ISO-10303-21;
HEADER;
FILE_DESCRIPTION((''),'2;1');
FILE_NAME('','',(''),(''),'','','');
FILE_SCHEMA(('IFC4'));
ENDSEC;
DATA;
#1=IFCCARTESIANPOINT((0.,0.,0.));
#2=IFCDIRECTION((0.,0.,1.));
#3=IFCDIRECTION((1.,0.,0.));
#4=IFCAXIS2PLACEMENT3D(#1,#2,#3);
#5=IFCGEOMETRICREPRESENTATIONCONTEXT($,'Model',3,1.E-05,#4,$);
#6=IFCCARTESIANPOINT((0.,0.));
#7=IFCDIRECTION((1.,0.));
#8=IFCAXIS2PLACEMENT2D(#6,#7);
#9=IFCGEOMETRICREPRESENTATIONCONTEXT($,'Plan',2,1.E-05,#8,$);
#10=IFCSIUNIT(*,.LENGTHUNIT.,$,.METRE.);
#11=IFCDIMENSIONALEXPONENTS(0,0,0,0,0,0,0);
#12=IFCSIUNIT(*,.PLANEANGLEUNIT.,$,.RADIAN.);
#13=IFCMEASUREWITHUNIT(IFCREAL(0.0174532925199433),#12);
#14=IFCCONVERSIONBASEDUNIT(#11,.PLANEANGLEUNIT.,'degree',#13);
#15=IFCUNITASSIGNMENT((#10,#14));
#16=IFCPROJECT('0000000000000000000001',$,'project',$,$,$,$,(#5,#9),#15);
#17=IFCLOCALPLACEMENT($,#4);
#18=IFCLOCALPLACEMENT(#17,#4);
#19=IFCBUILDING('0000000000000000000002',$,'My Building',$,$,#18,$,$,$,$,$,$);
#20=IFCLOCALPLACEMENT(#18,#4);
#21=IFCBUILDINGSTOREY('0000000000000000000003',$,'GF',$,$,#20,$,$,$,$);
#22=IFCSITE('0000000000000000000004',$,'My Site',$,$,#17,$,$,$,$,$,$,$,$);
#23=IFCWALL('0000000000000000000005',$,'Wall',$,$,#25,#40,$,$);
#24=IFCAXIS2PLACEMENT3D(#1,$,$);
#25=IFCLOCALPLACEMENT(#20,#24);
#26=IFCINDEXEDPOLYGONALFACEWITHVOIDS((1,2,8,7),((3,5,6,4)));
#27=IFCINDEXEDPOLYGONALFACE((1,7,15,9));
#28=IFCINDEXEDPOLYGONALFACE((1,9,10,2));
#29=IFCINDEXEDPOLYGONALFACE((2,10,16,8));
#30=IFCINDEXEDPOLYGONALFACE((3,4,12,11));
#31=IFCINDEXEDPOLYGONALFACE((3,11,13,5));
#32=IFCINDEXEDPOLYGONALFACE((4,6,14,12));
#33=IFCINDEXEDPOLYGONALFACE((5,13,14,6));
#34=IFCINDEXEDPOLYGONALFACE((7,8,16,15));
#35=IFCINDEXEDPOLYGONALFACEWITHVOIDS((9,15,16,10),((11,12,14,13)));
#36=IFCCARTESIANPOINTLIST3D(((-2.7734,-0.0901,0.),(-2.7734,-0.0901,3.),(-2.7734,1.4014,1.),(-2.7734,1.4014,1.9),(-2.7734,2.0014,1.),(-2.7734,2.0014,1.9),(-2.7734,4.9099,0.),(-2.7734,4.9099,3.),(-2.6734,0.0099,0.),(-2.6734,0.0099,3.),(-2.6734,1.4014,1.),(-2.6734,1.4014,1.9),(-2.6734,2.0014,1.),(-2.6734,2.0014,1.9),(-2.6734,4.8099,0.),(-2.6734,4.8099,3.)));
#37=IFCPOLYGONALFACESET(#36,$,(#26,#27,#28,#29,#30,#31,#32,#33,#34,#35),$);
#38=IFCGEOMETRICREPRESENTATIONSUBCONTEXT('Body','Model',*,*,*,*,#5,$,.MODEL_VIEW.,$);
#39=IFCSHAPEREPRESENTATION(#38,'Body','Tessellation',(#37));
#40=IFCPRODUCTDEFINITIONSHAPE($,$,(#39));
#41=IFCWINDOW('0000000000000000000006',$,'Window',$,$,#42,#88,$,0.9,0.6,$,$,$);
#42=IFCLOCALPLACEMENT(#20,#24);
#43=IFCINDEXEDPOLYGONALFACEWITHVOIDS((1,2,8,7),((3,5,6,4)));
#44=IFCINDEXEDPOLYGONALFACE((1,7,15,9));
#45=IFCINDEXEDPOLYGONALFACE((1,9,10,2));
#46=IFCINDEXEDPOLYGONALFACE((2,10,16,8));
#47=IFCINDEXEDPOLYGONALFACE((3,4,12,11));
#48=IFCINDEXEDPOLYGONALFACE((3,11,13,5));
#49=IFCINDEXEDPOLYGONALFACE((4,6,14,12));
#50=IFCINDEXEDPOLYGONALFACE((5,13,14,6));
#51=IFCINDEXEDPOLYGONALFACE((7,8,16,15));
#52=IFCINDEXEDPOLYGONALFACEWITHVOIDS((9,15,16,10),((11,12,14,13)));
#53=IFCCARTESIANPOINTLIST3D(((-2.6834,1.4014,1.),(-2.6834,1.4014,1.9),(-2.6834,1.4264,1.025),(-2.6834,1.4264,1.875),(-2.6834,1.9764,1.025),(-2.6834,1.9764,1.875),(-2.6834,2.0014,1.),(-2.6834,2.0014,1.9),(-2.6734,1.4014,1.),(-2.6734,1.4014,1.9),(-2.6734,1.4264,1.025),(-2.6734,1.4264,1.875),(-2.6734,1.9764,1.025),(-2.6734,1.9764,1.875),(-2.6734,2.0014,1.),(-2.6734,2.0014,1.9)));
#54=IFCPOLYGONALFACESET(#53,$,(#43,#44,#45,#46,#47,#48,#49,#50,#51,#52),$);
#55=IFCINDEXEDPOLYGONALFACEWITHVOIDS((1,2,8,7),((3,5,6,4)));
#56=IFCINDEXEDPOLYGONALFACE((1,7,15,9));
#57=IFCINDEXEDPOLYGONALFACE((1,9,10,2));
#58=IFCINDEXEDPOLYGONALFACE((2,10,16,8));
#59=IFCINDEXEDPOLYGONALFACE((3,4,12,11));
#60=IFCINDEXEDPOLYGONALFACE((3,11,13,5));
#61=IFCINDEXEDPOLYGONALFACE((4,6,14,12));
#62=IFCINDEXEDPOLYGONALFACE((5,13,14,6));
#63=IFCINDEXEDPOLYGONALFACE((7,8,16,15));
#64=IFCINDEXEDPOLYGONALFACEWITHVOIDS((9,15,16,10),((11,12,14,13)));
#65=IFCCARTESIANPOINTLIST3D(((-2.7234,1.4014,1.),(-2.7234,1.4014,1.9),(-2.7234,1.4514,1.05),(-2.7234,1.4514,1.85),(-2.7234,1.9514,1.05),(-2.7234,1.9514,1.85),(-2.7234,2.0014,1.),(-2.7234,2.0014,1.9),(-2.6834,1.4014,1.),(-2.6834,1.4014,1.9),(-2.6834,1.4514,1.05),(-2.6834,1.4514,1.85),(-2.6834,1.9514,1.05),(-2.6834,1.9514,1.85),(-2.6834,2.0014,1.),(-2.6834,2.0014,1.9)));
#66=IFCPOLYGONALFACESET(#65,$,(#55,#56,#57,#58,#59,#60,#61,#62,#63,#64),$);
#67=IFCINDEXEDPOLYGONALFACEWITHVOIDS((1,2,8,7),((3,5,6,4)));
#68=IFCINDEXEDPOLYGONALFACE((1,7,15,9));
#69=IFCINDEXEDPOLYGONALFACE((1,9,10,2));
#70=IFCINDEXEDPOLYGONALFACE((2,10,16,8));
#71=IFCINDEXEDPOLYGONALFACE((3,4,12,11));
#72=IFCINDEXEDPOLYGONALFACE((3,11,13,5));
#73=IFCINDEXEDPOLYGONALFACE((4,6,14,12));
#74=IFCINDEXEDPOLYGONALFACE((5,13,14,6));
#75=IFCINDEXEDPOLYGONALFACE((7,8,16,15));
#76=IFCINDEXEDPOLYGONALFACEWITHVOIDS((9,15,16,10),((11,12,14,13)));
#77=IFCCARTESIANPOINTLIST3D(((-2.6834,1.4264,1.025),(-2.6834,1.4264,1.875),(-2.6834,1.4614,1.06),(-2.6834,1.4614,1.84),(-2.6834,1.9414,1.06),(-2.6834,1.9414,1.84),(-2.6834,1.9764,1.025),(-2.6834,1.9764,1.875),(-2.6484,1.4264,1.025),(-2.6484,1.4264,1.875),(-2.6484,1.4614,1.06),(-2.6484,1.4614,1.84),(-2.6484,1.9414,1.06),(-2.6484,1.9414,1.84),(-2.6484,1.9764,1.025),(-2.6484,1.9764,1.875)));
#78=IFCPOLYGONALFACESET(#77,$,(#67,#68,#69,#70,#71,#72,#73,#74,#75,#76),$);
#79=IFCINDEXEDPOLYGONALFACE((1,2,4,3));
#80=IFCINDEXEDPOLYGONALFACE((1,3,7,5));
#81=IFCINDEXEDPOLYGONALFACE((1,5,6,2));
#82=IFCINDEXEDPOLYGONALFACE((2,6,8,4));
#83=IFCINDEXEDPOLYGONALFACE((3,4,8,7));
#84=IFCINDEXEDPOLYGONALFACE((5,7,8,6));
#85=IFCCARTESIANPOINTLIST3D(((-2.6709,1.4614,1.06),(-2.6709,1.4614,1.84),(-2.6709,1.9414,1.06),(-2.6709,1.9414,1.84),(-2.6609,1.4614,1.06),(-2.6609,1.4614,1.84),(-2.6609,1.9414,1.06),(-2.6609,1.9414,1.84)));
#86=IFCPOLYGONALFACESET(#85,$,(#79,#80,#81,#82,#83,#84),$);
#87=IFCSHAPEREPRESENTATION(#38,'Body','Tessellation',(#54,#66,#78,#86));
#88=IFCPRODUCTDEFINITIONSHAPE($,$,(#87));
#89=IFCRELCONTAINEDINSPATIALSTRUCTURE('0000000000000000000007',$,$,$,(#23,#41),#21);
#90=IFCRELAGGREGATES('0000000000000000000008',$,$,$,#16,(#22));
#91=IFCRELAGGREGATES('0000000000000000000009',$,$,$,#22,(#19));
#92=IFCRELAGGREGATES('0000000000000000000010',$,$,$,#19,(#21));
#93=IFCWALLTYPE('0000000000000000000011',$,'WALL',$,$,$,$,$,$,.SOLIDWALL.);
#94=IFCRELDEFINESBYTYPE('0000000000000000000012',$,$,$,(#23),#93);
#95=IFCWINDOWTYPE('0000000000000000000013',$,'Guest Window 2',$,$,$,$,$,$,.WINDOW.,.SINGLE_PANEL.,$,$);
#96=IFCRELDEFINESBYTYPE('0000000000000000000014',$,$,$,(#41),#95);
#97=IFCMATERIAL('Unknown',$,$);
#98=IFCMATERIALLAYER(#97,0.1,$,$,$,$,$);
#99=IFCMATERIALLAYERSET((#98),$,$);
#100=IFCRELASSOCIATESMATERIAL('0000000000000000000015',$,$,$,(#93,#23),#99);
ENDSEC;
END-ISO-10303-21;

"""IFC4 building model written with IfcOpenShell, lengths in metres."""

from ifc_helpers import new_model, entity, si_unit, converted_unit, frame, origin_with_axes, origin_2d_with_axis, place, context, subcontext, project, spatial, line, indexed_curve, outline, extrude, shape, source, transform, mapped, material, layer, layer_set, layer_usage, type_object, type_shapes, element, fill, save


model = new_model("IFC4")

# Units and contexts
model_context = context("Model", 3, precision=1e-05, world=origin_with_axes())
plan_context = context("Plan", 2, precision=1e-05, world=origin_2d_with_axis())
body_context_1 = subcontext(model_context, "Body", "Model", "MODEL_VIEW")
body_context_2 = subcontext(plan_context, "Body", "Plan", "PLAN_VIEW")
ifc_project = project(units=[si_unit("LENGTHUNIT", "METRE"), converted_unit("PLANEANGLEUNIT", "degree", entity("IfcReal", 0.0174532925199433), si_unit("PLANEANGLEUNIT", "RADIAN"), dimensions=[0, 0, 0, 0, 0, 0, 0])], contexts=[model_context, plan_context])

# Site, building, storey
site_placement = place(None, origin_with_axes())
site = spatial("IfcSite", under=ifc_project, at=site_placement, Name="My Site")
building_placement = place(site_placement, origin_with_axes())
building = spatial("IfcBuilding", under=site, at=building_placement, Name="My Building")
storey_placement = place(building_placement, origin_with_axes())
storey = spatial("IfcBuildingStorey", under=building, at=storey_placement, Name="GF")

# Shared definitions
ifc_material_1 = material(Name="Unknown")

# Shared definitions
ifc_layer_1 = layer(ifc_material_1, 0.1)
ifc_layer_set_1 = layer_set([ifc_layer_1])
wall_type = type_object("IfcWallType", Name="WALL", PredefinedType="SOLIDWALL", material=ifc_layer_set_1)

# Wall, opening, window
ifc_layer_usage_1 = layer_usage(ifc_layer_set_1, "AXIS2", "POSITIVE", 0.0)
wall_1_placement = place(storey_placement, frame((-2.7734, 4.9099, 0.0), z_axis=(0.0, 0.0, 1.0), x_axis=(0.0, -1.0, 0.0)))
wall_1 = element("IfcWall", 1, at=wall_1_placement, inside=storey, type_object=wall_type, material=ifc_layer_usage_1, Name="Wall", context=body_context_1, shape_type="SweptSolid", body=[
    extrude(outline(indexed_curve([(0.0, 0.0), (0.1, 0.1), (4.9, 0.1), (5.0, 0.0)], segments=[line(1, 2, 3, 4, 1)])), origin_with_axes(), (0.0, 0.0, 1.0), 3.0),
])
shared_shape_1 = source(origin_with_axes(), body_context_1, "Body", "SweptSolid", [
    extrude(outline(indexed_curve([(0.0, 0.0), (0.6, 0.0), (0.6, 0.9), (0.0, 0.9)], segments=[line(1, 2, 3, 4, 1)])), frame((0.0, -0.6, 0.0), z_axis=(0.0, -1.0, 0.0), x_axis=(1.0, 0.0, 0.0)), (0.0, 0.0, -1.0), 1.2),
])
opening_1_placement = place(wall_1_placement, frame((2.9085, 0.0, 1.0), z_axis=(0.0, 0.0, 1.0), x_axis=(1.0, 0.0, 0.0)))
opening_1 = element("IfcOpeningElement", 2, at=opening_1_placement, cuts=wall_1, PredefinedType="OPENING", context=body_context_1, shape_type="MappedRepresentation", body=[
    mapped(shared_shape_1, transform((0.0, 0.0, 0.0), x_axis=(1.0, 0.0, 0.0), y_axis=(0.0, 1.0, 0.0), z_axis=(0.0, 0.0, 1.0), scale=1.0)),
])
window_type_1 = type_object("IfcWindowType", Name="Guest Window 2", PartitioningType="SINGLE_PANEL", PredefinedType="WINDOW")
shared_shape_2 = source(origin_with_axes(), body_context_1, "Body", "SweptSolid", [
    extrude(outline(indexed_curve([(0.0, 0.0), (0.6, 0.0), (0.6, 0.9), (0.0, 0.9)], segments=[line(1, 2, 3, 4, 1)]), holes=[indexed_curve([(0.025, 0.025), (0.575, 0.025), (0.575, 0.875), (0.025, 0.875)], segments=[line(1, 2, 3, 4, 1)])]), frame((0.0, 0.09, 0.0), z_axis=(0.0, -1.0, 0.0), x_axis=(1.0, 0.0, 0.0)), (0.0, 0.0, -1.0), 0.01),
    extrude(outline(indexed_curve([(0.0, 0.0), (0.6, 0.0), (0.6, 0.9), (0.0, 0.9)], segments=[line(1, 2, 3, 4, 1)]), holes=[indexed_curve([(0.05, 0.05), (0.55, 0.05), (0.55, 0.85), (0.05, 0.85)], segments=[line(1, 2, 3, 4, 1)])]), frame((0.0, 0.05, 0.0), z_axis=(0.0, -1.0, 0.0), x_axis=(1.0, 0.0, 0.0)), (0.0, 0.0, -1.0), 0.04),
    extrude(outline(indexed_curve([(0.0, 0.0), (0.55, 0.0), (0.55, 0.85), (0.0, 0.85)], segments=[line(1, 2, 3, 4, 1)]), holes=[indexed_curve([(0.035, 0.035), (0.515, 0.035), (0.515, 0.815), (0.035, 0.815)], segments=[line(1, 2, 3, 4, 1)])]), frame((0.025, 0.09, 0.025), z_axis=(0.0, -1.0, 0.0), x_axis=(1.0, 0.0, 0.0)), (0.0, 0.0, -1.0), 0.035),
    extrude(outline(indexed_curve([(0.035, 0.035), (0.515, 0.035), (0.515, 0.815), (0.035, 0.815)], segments=[line(1, 2, 3, 4, 1)])), frame((0.025, 0.1025, 0.025), z_axis=(0.0, -1.0, 0.0), x_axis=(1.0, 0.0, 0.0)), (0.0, 0.0, -1.0), 0.01),
])
shared_shape_3 = source(origin_with_axes(), body_context_2, "Body", "Curve2D", [
    entity("IfcIndexedPolyCurve", entity("IfcCartesianPointList2D", [[0.05, 0.05], [0.55, 0.05]])),
    entity("IfcIndexedPolyCurve", entity("IfcCartesianPointList2D", [[0.0, 0.1], [0.025, 0.1], [0.025, 0.09], [0.05, 0.09], [0.05, 0.05], [0.0, 0.05]]), [entity("IfcLineIndex", [1, 2, 3, 4, 5, 6, 1])]),
    entity("IfcIndexedPolyCurve", entity("IfcCartesianPointList2D", [[0.6, 0.1], [0.575, 0.1], [0.575, 0.09], [0.55, 0.09], [0.55, 0.05], [0.6, 0.05]]), [entity("IfcLineIndex", [1, 2, 3, 4, 5, 6, 1])]),
    entity("IfcIndexedPolyCurve", entity("IfcCartesianPointList2D", [[0.025, 0.09], [0.06, 0.09], [0.06, 0.125], [0.025, 0.125]]), [entity("IfcLineIndex", [1, 2, 3, 4, 1])]),
    entity("IfcIndexedPolyCurve", entity("IfcCartesianPointList2D", [[0.575, 0.09], [0.54, 0.09], [0.54, 0.125], [0.575, 0.125]]), [entity("IfcLineIndex", [1, 2, 3, 4, 1])]),
    entity("IfcIndexedPolyCurve", entity("IfcCartesianPointList2D", [[0.06, 0.09], [0.54, 0.09]])),
    entity("IfcIndexedPolyCurve", entity("IfcCartesianPointList2D", [[0.06, 0.125], [0.54, 0.125]])),
    entity("IfcIndexedPolyCurve", entity("IfcCartesianPointList2D", [[0.06, 0.1075], [0.54, 0.1075]])),
])
type_shapes(window_type_1, [shared_shape_2, shared_shape_3])
window_1_placement = place(opening_1_placement, origin_with_axes())
window_1 = element("IfcWindow", 3, at=window_1_placement, inside=storey, type_object=window_type_1, Name="Window", OverallHeight=0.9, OverallWidth=0.6, shapes=[
    shape(body_context_1, "Body", "MappedRepresentation", [mapped(shared_shape_2, transform((0.0, 0.0, 0.0), x_axis=(1.0, 0.0, 0.0), y_axis=(0.0, 1.0, 0.0), z_axis=(0.0, 0.0, 1.0), scale=1.0))]),
    shape(body_context_2, "Body", "MappedRepresentation", [mapped(shared_shape_3, transform((0.0, 0.0, 0.0), x_axis=(1.0, 0.0, 0.0), y_axis=(0.0, 1.0, 0.0), z_axis=(0.0, 0.0, 1.0), scale=1.0))]),
])
fill(opening_1, window_1)

save(model, "model.ifc")
